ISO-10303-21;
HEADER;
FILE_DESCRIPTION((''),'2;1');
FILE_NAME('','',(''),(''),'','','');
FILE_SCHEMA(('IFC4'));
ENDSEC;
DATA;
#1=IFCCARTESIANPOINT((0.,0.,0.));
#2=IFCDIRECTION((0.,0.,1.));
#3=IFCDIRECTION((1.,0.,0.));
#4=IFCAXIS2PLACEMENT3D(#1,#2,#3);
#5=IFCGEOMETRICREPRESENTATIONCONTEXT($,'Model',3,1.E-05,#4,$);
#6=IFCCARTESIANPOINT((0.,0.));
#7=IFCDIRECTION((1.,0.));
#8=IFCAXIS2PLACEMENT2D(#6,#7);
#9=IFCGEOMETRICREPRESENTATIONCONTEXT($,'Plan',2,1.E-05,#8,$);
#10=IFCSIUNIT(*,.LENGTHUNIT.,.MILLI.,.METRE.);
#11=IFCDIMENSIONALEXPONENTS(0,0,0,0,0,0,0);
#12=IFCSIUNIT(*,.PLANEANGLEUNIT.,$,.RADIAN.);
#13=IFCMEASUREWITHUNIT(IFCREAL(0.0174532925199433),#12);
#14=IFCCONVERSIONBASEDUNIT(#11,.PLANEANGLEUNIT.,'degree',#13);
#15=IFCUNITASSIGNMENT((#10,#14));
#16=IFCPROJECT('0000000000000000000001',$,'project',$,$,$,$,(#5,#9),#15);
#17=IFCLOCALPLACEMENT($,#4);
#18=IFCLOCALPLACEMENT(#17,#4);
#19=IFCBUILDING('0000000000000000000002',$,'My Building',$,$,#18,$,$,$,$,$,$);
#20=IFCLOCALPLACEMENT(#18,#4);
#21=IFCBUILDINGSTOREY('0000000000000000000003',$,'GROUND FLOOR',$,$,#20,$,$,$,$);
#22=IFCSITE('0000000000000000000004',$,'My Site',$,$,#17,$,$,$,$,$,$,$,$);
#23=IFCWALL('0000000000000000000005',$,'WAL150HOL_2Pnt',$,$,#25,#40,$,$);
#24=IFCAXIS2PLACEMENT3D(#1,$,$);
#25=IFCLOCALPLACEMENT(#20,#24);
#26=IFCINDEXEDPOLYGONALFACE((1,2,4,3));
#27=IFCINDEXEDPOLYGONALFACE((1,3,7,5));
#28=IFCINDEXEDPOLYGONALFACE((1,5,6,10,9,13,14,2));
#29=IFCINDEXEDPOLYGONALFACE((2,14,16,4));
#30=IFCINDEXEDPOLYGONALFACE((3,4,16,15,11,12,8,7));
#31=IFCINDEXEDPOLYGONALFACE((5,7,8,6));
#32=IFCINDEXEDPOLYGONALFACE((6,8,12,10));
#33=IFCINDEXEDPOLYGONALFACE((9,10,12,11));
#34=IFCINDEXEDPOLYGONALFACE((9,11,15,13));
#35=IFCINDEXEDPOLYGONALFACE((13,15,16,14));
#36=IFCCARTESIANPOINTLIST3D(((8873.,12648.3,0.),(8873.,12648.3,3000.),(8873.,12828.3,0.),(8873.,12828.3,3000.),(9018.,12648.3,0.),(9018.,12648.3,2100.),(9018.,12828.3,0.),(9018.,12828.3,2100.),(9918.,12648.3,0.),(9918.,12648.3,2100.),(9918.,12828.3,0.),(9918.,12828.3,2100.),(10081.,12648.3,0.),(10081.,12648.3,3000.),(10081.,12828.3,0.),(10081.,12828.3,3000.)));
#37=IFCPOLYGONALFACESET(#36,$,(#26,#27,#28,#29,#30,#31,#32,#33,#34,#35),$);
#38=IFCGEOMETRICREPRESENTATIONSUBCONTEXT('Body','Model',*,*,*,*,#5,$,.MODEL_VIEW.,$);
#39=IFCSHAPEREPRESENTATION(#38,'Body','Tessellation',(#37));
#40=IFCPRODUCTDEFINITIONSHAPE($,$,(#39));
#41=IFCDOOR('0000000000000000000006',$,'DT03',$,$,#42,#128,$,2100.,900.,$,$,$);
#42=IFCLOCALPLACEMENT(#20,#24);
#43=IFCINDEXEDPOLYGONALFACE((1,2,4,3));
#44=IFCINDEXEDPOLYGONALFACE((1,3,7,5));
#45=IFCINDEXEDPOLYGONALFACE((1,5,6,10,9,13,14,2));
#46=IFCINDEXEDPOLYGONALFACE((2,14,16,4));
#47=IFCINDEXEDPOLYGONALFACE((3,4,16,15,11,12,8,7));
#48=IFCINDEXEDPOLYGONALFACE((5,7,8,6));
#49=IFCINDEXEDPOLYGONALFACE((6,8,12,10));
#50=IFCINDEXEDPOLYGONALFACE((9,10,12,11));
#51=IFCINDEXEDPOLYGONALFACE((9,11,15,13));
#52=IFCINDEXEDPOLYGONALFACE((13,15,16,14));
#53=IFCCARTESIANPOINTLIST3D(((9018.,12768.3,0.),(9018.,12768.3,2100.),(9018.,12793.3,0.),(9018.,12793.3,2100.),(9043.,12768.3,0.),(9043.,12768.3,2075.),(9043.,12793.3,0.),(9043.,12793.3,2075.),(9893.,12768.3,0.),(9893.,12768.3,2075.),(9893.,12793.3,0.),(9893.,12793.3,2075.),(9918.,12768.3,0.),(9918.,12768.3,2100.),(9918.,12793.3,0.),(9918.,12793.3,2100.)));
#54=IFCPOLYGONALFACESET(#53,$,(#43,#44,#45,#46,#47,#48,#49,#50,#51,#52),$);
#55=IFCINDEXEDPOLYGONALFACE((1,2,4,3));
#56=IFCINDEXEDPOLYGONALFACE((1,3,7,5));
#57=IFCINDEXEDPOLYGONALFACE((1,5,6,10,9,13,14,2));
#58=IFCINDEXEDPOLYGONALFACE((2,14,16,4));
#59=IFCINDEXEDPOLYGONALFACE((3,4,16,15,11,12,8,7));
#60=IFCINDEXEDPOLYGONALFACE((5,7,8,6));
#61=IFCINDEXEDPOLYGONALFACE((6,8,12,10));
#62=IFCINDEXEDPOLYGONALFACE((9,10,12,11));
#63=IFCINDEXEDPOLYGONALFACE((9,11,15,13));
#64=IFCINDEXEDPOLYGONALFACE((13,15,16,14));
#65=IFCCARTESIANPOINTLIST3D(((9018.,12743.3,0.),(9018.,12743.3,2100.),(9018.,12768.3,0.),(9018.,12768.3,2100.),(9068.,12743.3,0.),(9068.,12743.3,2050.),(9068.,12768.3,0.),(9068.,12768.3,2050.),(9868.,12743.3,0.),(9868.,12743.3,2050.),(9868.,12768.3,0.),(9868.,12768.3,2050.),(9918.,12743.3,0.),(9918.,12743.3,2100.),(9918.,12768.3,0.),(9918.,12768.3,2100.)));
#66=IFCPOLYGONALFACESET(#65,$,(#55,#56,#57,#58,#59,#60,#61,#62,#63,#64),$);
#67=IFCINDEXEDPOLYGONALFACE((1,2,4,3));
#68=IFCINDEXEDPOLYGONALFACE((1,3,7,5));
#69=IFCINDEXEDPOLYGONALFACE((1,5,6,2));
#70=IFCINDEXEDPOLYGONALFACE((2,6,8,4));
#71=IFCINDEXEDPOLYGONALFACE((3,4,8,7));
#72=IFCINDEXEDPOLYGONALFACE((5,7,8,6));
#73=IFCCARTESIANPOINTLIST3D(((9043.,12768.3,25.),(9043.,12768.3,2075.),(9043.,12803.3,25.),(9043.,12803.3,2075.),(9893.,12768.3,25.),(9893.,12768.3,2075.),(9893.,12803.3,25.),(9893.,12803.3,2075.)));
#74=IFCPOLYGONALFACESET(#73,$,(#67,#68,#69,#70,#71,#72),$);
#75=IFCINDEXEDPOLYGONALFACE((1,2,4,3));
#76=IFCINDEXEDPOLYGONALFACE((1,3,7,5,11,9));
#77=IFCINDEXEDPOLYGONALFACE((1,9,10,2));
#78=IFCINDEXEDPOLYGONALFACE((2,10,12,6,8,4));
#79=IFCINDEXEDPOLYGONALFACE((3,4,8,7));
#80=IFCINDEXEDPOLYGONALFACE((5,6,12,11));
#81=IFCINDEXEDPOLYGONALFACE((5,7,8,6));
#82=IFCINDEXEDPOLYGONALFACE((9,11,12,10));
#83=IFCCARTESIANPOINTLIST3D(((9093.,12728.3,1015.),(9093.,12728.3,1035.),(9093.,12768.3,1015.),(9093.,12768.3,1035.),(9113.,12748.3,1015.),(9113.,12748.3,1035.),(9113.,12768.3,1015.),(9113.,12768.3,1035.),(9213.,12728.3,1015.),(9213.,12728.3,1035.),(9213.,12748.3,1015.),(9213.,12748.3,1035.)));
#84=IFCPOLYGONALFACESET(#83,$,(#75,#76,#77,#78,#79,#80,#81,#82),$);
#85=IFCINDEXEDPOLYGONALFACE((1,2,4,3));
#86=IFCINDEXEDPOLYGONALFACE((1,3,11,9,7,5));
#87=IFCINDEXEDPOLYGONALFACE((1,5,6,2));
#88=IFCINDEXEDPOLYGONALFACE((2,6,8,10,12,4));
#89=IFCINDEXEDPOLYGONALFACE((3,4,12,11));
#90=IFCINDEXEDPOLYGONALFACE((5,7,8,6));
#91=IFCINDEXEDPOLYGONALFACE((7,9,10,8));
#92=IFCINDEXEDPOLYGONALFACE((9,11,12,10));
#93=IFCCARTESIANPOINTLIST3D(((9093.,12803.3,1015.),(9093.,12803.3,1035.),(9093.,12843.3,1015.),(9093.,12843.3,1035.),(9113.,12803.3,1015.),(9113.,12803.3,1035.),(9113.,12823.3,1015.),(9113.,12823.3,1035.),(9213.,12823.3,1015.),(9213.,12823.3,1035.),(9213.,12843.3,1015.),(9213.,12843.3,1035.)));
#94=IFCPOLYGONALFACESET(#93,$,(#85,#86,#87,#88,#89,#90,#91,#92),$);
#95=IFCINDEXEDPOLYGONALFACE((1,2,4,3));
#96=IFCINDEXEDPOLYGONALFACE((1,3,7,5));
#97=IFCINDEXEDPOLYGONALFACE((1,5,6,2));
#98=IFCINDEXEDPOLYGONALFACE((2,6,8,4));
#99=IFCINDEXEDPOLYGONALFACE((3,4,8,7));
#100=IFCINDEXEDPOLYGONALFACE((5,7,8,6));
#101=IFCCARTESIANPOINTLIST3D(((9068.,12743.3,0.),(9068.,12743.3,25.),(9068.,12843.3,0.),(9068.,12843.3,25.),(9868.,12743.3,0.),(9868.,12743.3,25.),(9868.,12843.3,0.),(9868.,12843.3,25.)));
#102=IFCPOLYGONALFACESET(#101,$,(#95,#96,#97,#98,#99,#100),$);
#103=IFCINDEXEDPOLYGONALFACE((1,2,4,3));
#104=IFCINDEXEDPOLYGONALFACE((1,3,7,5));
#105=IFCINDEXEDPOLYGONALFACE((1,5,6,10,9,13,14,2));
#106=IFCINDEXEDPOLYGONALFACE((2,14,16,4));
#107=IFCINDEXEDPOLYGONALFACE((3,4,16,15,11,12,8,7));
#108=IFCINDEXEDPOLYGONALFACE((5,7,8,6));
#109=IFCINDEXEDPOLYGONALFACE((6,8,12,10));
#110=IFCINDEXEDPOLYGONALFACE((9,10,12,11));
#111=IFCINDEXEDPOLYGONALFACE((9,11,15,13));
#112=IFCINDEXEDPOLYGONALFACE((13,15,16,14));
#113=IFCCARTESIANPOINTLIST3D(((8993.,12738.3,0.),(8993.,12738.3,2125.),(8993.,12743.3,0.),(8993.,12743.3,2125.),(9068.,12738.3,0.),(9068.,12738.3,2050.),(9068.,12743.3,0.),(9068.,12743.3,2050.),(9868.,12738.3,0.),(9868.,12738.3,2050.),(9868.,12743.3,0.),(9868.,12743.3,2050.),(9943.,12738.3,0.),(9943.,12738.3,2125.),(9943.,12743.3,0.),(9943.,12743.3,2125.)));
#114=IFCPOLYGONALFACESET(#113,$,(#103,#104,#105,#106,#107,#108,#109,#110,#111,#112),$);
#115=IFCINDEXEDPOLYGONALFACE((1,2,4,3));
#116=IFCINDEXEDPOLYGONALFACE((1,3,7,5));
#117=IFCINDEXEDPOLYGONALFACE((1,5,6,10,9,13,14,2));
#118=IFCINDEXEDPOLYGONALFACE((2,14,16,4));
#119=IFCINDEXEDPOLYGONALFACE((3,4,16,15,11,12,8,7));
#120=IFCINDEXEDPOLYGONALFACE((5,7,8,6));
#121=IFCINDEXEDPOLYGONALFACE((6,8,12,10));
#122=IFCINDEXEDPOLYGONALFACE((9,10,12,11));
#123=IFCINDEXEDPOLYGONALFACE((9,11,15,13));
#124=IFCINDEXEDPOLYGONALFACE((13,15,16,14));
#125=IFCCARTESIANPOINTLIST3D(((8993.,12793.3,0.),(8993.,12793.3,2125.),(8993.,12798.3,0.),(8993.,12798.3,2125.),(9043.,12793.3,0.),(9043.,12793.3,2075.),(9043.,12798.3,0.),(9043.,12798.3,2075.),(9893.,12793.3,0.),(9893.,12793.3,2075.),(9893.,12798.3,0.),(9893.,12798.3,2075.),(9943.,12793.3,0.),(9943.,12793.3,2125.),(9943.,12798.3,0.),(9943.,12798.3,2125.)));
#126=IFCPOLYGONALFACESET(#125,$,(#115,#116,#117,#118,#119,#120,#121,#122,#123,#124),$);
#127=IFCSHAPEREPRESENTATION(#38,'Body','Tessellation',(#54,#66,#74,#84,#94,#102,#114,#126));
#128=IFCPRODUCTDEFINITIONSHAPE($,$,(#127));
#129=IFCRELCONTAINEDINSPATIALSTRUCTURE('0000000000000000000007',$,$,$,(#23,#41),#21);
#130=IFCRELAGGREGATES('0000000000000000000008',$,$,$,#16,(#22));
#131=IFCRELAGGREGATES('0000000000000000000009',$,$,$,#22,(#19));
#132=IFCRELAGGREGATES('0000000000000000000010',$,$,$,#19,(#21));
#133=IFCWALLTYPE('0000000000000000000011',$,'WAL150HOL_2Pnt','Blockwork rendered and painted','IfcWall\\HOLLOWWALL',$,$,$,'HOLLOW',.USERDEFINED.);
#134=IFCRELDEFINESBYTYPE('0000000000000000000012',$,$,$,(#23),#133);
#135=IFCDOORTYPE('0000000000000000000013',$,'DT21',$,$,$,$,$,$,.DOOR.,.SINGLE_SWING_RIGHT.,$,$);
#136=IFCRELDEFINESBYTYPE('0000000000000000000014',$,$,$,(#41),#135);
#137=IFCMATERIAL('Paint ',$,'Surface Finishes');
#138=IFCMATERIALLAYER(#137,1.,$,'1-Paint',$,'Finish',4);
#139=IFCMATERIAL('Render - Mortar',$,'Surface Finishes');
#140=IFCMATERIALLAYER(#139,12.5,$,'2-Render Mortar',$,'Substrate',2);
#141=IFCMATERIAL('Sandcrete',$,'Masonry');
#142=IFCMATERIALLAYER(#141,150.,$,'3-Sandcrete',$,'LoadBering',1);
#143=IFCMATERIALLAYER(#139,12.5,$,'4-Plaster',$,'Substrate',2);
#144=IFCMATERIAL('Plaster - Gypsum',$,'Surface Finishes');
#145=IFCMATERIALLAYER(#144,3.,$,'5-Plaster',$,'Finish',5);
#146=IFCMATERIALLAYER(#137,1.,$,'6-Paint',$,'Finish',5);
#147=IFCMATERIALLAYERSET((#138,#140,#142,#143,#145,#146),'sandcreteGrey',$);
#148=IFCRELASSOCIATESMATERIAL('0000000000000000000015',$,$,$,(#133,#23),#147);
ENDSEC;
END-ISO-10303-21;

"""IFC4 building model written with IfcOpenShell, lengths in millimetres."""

from ifc_helpers import new_model, entity, si_unit, converted_unit, frame, origin_with_axes, origin_2d_with_axis, place, context, subcontext, project, spatial, line, indexed_curve, outline, extrude, shape, source, transform, mapped, material, layer, layer_set, layer_usage, type_object, type_shapes, element, fill, save


model = new_model("IFC4")

# Units and contexts
model_context = context("Model", 3, precision=1e-05, world=origin_with_axes())
plan_context = context("Plan", 2, precision=1e-05, world=origin_2d_with_axis())
body_context_1 = subcontext(model_context, "Body", "Model", "MODEL_VIEW")
body_context_2 = subcontext(plan_context, "Body", "Plan", "PLAN_VIEW")
ifc_project = project(units=[si_unit("LENGTHUNIT", "METRE", prefix="MILLI"), converted_unit("PLANEANGLEUNIT", "degree", entity("IfcReal", 0.0174532925199433), si_unit("PLANEANGLEUNIT", "RADIAN"), dimensions=[0, 0, 0, 0, 0, 0, 0])], contexts=[model_context, plan_context])

# Site, building, storey
site_placement = place(None, origin_with_axes())
site = spatial("IfcSite", under=ifc_project, at=site_placement, Name="My Site")
building_placement = place(site_placement, origin_with_axes())
building = spatial("IfcBuilding", under=site, at=building_placement, Name="My Building")
storey_placement = place(building_placement, origin_with_axes())
storey = spatial("IfcBuildingStorey", under=building, at=storey_placement, Name="GROUND FLOOR")

# Shared definitions
ifc_material_1 = material(Name="Paint ", Category="Surface Finishes")
ifc_layer_1 = layer(ifc_material_1, 1.0, Name="1-Paint", Category="Finish", Priority=4)
ifc_material_2 = material(Name="Render - Mortar", Category="Surface Finishes")
ifc_layer_2 = layer(ifc_material_2, 12.5, Name="2-Render Mortar", Category="Substrate", Priority=2)
ifc_material_3 = material(Name="Sandcrete", Category="Masonry")
ifc_layer_3 = layer(ifc_material_3, 150.0, Name="3-Sandcrete", Category="LoadBering", Priority=1)
ifc_layer_4 = layer(ifc_material_2, 12.5, Name="4-Plaster", Category="Substrate", Priority=2)
ifc_material_4 = material(Name="Plaster - Gypsum", Category="Surface Finishes")
ifc_layer_5 = layer(ifc_material_4, 3.0, Name="5-Plaster", Category="Finish", Priority=5)
ifc_layer_6 = layer(ifc_material_1, 1.0, Name="6-Paint", Category="Finish", Priority=5)
ifc_layer_set_1 = layer_set([ifc_layer_1, ifc_layer_2, ifc_layer_3, ifc_layer_4, ifc_layer_5, ifc_layer_6], Name="sandcreteGrey")
wall_type_1 = type_object("IfcWallType", Name="WAL150HOL_2Pnt", Description="Blockwork rendered and painted", ApplicableOccurrence="IfcWall\\HOLLOWWALL", ElementType="HOLLOW", PredefinedType="USERDEFINED", material=ifc_layer_set_1)

# Shared definitions
shared_shape_1 = source(origin_with_axes(), body_context_1, "Body", "SweptSolid", [
    extrude(outline(indexed_curve([(0.0, 0.0), (900.0, 0.0), (900.0, 2100.0), (0.0, 2100.0)], segments=[line(1, 2, 3, 4, 1)])), frame((0.0, -600.0, 0.0), z_axis=(0.0, -1.0, 0.0), x_axis=(1.0, 0.0, 0.0)), (0.0, 0.0, -1.0), 1200.0),
])
door_type_1 = type_object("IfcDoorType", Name="DT21", OperationType="SINGLE_SWING_RIGHT", PredefinedType="DOOR")
shared_shape_2 = source(origin_with_axes(), body_context_1, "Body", "SweptSolid", [
    extrude(outline(indexed_curve([(0.0, 0.0), (0.0, 2100.0), (900.0, 2100.0), (900.0, 0.0), (875.0, 0.0), (875.0, 2075.0), (25.0, 2075.0), (25.0, 0.0)], segments=[line(1, 2, 3, 4, 5, 6, 7, 8, 1)])), frame((0.0, 25.0, 0.0), z_axis=(0.0, -1.0, 0.0), x_axis=(1.0, 0.0, 0.0)), (0.0, 0.0, -1.0), 25.0),
    extrude(outline(indexed_curve([(0.0, 0.0), (0.0, 2100.0), (900.0, 2100.0), (900.0, 0.0), (850.0, 0.0), (850.0, 2050.0), (50.0, 2050.0), (50.0, 0.0)], segments=[line(1, 2, 3, 4, 5, 6, 7, 8, 1)])), frame((0.0, 0.0, 0.0), z_axis=(0.0, -1.0, 0.0), x_axis=(1.0, 0.0, 0.0)), (0.0, 0.0, -1.0), 25.0),
    extrude(outline(indexed_curve([(0.0, 0.0), (850.0, 0.0), (850.0, 35.0), (0.0, 35.0)], segments=[line(1, 2, 3, 4, 1)])), frame((25.0, 25.0, 25.0), z_axis=(0.0, 0.0, 1.0), x_axis=(1.0, 0.0, 0.0)), (0.0, 0.0, 1.0), 2050.0),
    extrude(outline(indexed_curve([(0.0, 0.0), (0.0, -40.0), (120.0, -40.0), (120.0, -20.0), (20.0, -20.0), (20.0, 0.0)], segments=[line(1, 2, 3, 4, 5, 6, 1)])), frame((75.0, 25.0, 1015.0), z_axis=(0.0, 0.0, 1.0), x_axis=(1.0, 0.0, 0.0)), (0.0, 0.0, 1.0), 20.0),
    extrude(outline(indexed_curve([(0.0, 0.0), (0.0, 40.0), (120.0, 40.0), (120.0, 20.0), (20.0, 20.0), (20.0, 0.0)], segments=[line(1, 2, 3, 4, 5, 6, 1)])), frame((75.0, 60.0, 1015.0), z_axis=(0.0, 0.0, 1.0), x_axis=(1.0, 0.0, 0.0)), (0.0, 0.0, 1.0), 20.0),
    extrude(outline(indexed_curve([(0.0, 0.0), (800.0, 0.0), (800.0, 100.0), (0.0, 100.0)], segments=[line(1, 2, 3, 4, 1)])), frame((50.0, 0.0, 0.0), z_axis=(0.0, 0.0, 1.0), x_axis=(1.0, 0.0, 0.0)), (0.0, 0.0, 1.0), 25.0),
    extrude(outline(indexed_curve([(0.0, 0.0), (0.0, 2125.0), (950.0, 2125.0), (950.0, 0.0), (875.0, 0.0), (875.0, 2050.0), (75.0, 2050.0), (75.0, 0.0)], segments=[line(1, 2, 3, 4, 5, 6, 7, 8, 1)])), frame((-25.0, -5.0, 0.0), z_axis=(0.0, -1.0, 0.0), x_axis=(1.0, 0.0, 0.0)), (0.0, 0.0, -1.0), 5.0),
    extrude(outline(indexed_curve([(0.0, 0.0), (0.0, 2125.0), (950.0, 2125.0), (950.0, 0.0), (900.0, 0.0), (900.0, 2075.0), (50.0, 2075.0), (50.0, 0.0)], segments=[line(1, 2, 3, 4, 5, 6, 7, 8, 1)])), frame((-25.0, 50.0, 0.0), z_axis=(0.0, -1.0, 0.0), x_axis=(1.0, 0.0, 0.0)), (0.0, 0.0, -1.0), 5.0),
])
shared_shape_3 = source(origin_with_axes(), body_context_2, "Body", "Curve2D", [
    entity("IfcIndexedPolyCurve", entity("IfcCartesianPointList2D", [[0.0, 0.0], [0.0, 50.0], [25.0, 50.0], [25.0, 25.0], [50.0, 25.0], [50.0, 0.0]]), [entity("IfcLineIndex", [1, 2, 3, 4, 5, 6, 1])]),
    entity("IfcIndexedPolyCurve", entity("IfcCartesianPointList2D", [[900.0, 0.0], [900.0, 50.0], [875.0, 50.0], [875.0, 25.0], [850.0, 25.0], [850.0, 0.0]]), [entity("IfcLineIndex", [1, 2, 3, 4, 5, 6, 1])]),
    entity("IfcTrimmedCurve", entity("IfcEllipse", entity("IfcAxis2Placement2D", entity("IfcCartesianPoint", [840.0, 50.0]), entity("IfcDirection", [1.0, 0.0])), 815.0, 850.0), [entity("IfcCartesianPoint", [840.0, 900.0])], [entity("IfcCartesianPoint", [25.0, 50.0])], True, "CARTESIAN"),
    entity("IfcIndexedPolyCurve", entity("IfcCartesianPointList2D", [[875.0, 50.0], [840.0, 50.0], [840.0, 900.0], [875.0, 900.0]]), [entity("IfcLineIndex", [1, 2, 3, 4, 1])]),
])
type_shapes(door_type_1, [shared_shape_2, shared_shape_3])

# Wall, opening, door
ifc_layer_usage_1 = layer_usage(ifc_layer_set_1, "AXIS2", "POSITIVE", 0.0)
wall_1_placement = place(storey_placement, frame((10081.0, 12828.3, 0.0), z_axis=(0.0, 0.0, 1.0), x_axis=(-1.0, 0.000001, 0.0)))
wall_1 = element("IfcWall", 1, at=wall_1_placement, inside=storey, type_object=wall_type_1, material=ifc_layer_usage_1, Name="WAL150HOL_2Pnt", context=body_context_1, shape_type="SweptSolid", body=[
    extrude(outline(indexed_curve([(0.0, 0.0), (0.0, 180.0), (1208.0, 180.0), (1208.0, 0.0), (0.0, 0.0)], self_intersect=False)), origin_with_axes(), (0.0, 0.0, 1.0), 3000.0),
])
opening_1_placement = place(wall_1_placement, frame((1063.0, 85.0, 0.0), z_axis=(0.0, 0.0, 1.0), x_axis=(-1.0, 0.0, 0.0)))
opening_1 = element("IfcOpeningElement", 2, at=opening_1_placement, cuts=wall_1, PredefinedType="OPENING", context=body_context_1, shape_type="MappedRepresentation", body=[
    mapped(shared_shape_1, transform((0.0, 0.0, 0.0), x_axis=(1.0, 0.0, 0.0), y_axis=(0.0, 1.0, 0.0), z_axis=(0.0, 0.0, 1.0), scale=1.0)),
])
door_1_placement = place(opening_1_placement, origin_with_axes())
door_1 = element("IfcDoor", 3, at=door_1_placement, inside=storey, type_object=door_type_1, Name="DT03", OverallHeight=2100.0, OverallWidth=900.0, shapes=[
    shape(body_context_1, "Body", "MappedRepresentation", [mapped(shared_shape_2, transform((0.0, 0.0, 0.0), x_axis=(1.0, 0.0, 0.0), y_axis=(0.0, 1.0, 0.0), z_axis=(0.0, 0.0, 1.0), scale=1.0))]),
    shape(body_context_2, "Body", "MappedRepresentation", [mapped(shared_shape_3, transform((0.0, 0.0, 0.0), x_axis=(1.0, 0.0, 0.0), y_axis=(0.0, 1.0, 0.0), z_axis=(0.0, 0.0, 1.0), scale=1.0))]),
])
fill(opening_1, door_1)

save(model, "model.ifc")
